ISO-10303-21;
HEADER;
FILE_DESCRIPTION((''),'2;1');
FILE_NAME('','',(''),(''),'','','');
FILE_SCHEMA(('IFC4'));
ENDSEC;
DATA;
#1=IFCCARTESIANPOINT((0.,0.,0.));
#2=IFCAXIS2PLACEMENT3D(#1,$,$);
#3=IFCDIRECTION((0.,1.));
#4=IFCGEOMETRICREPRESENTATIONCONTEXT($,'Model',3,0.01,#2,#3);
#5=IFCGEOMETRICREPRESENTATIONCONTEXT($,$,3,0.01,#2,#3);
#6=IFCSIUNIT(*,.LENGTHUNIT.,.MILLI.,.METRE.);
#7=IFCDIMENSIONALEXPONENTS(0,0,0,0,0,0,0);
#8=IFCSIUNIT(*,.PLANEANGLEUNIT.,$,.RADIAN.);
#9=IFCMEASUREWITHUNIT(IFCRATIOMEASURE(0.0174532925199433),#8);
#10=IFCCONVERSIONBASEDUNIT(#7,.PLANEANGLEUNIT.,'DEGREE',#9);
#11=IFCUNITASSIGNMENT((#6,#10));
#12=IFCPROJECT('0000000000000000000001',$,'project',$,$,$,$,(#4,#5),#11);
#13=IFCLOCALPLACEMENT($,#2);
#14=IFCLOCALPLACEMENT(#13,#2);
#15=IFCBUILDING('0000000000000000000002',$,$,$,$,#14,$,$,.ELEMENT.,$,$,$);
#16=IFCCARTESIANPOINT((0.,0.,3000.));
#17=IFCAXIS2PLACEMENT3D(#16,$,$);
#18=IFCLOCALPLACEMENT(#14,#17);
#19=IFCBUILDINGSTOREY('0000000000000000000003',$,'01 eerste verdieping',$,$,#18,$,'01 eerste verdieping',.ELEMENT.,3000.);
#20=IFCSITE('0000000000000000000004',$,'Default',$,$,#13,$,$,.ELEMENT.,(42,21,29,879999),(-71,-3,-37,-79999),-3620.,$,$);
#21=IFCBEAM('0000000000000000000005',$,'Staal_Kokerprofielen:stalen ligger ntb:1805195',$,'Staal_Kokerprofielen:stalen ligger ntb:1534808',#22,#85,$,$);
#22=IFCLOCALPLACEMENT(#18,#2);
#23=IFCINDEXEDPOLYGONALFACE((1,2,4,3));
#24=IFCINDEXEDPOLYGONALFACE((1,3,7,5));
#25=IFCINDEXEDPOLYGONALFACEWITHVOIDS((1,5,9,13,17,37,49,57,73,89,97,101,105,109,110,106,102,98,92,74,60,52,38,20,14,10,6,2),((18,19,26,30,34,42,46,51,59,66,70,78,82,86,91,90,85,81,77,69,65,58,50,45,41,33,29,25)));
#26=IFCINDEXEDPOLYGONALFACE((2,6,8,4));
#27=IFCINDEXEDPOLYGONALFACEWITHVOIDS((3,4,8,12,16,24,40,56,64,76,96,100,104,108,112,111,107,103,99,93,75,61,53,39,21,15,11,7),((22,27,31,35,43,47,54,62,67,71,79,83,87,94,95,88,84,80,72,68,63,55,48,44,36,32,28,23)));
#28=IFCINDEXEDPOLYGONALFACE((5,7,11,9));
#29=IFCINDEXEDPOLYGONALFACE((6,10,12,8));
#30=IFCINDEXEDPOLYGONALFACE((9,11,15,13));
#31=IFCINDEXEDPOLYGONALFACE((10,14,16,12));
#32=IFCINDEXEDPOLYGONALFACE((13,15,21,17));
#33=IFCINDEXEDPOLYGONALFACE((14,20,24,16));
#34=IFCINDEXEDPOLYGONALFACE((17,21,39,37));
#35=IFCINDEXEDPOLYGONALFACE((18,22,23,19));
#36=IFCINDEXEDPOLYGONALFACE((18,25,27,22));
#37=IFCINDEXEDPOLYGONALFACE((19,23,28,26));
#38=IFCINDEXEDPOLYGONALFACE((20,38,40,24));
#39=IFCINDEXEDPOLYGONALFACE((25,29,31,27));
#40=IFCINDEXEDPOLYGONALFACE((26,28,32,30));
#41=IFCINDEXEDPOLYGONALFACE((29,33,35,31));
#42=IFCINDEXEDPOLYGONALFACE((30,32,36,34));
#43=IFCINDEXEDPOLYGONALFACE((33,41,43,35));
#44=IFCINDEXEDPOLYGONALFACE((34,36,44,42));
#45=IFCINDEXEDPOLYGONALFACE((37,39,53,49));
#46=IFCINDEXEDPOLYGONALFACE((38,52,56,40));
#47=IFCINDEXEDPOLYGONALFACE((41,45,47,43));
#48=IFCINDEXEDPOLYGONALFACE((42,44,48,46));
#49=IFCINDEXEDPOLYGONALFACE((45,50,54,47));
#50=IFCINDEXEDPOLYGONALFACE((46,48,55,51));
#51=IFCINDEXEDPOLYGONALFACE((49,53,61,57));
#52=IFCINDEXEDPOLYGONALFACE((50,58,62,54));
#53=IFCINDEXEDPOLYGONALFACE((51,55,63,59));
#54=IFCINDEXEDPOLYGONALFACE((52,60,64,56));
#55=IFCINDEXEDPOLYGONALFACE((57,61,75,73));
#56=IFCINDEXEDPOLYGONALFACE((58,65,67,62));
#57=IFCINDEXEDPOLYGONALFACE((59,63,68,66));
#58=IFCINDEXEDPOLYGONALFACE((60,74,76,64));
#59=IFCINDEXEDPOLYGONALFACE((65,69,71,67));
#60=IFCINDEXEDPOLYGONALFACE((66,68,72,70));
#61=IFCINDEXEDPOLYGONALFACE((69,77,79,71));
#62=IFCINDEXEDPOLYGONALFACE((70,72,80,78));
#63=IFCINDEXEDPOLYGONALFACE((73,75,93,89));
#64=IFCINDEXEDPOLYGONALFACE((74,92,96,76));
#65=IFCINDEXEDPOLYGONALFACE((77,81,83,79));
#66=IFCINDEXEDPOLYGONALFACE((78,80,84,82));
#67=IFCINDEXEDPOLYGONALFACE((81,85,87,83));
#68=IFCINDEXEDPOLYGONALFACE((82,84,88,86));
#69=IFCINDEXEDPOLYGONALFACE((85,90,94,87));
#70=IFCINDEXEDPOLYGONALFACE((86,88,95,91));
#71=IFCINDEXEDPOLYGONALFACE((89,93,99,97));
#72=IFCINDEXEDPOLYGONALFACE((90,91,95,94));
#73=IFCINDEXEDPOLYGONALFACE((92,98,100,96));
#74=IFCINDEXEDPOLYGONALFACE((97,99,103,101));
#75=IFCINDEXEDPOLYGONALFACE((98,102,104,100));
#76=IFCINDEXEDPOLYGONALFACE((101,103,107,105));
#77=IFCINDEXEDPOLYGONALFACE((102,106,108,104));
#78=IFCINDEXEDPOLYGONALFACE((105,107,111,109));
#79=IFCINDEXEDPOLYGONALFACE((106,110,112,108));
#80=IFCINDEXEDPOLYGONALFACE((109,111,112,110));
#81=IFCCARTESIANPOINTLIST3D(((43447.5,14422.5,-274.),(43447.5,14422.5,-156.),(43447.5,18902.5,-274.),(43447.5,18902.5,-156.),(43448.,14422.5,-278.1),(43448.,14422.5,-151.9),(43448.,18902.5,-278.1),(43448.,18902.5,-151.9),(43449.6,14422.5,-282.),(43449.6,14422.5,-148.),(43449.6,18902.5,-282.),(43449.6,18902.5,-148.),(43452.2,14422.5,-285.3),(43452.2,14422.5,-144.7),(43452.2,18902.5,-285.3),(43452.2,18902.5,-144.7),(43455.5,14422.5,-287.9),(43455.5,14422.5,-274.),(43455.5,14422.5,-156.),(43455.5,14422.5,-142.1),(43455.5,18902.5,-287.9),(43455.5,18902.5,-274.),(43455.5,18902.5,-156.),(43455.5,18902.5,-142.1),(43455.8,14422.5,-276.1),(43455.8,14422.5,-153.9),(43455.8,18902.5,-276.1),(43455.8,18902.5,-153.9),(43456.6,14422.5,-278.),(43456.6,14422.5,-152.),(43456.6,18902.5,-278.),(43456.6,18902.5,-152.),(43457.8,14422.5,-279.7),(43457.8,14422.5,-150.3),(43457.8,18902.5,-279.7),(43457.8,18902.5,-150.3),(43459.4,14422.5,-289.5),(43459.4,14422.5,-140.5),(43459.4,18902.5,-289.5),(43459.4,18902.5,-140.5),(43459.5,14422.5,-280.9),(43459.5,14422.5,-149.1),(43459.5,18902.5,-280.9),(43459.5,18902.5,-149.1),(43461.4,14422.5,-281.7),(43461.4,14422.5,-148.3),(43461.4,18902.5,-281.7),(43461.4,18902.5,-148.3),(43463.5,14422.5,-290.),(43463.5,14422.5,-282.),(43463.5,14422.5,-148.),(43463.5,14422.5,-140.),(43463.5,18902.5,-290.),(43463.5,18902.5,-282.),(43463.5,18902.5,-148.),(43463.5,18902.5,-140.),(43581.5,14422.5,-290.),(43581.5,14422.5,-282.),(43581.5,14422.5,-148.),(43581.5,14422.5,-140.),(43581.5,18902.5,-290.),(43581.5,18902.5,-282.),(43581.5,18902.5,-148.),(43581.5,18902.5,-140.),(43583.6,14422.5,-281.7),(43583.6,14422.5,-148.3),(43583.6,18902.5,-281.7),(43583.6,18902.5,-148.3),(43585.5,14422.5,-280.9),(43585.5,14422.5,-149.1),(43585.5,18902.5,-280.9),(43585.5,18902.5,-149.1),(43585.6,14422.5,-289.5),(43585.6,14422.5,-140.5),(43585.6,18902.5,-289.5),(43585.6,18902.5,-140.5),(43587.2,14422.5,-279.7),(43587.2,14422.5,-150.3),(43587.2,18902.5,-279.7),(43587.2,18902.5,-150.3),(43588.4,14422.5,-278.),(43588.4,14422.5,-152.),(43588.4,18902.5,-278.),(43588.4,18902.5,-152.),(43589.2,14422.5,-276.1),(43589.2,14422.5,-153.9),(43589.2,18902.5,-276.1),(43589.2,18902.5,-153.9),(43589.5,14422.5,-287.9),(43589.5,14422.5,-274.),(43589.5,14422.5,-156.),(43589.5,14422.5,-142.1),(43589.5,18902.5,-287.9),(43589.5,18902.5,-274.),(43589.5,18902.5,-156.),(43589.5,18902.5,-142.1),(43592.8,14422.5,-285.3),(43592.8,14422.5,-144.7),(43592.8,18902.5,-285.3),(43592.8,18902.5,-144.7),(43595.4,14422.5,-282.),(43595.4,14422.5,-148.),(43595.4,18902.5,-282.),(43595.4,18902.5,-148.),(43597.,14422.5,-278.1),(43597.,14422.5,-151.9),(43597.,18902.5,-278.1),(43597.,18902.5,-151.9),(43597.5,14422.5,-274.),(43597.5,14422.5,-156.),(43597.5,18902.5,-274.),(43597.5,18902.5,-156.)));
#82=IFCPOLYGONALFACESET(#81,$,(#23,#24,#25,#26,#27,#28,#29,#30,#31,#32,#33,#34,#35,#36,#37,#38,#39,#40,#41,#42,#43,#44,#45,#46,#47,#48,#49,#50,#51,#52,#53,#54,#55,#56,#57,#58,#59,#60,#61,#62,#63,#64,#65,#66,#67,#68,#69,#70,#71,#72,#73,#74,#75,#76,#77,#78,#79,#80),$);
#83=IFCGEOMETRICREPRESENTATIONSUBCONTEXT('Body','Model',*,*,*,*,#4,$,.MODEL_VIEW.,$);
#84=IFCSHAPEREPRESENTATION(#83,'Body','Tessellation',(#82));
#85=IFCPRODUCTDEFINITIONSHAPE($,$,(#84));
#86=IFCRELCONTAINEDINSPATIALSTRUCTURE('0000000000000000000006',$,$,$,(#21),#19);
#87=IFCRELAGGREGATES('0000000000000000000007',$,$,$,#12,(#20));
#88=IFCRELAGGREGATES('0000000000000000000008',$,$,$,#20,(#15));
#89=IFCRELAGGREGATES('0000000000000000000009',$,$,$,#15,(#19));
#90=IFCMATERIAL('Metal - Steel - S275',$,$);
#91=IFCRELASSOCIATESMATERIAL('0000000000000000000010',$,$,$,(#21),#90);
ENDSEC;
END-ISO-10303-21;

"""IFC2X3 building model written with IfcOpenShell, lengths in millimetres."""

from ifc_helpers import new_model, entity, si_unit, converted_unit, direction, frame, frame_2d, origin, place, context, subcontext, project, spatial, polyline, circle_curve, parameter, trimmed, segment, composite_curve, outline, extrude, material, element, save


model = new_model("IFC2X3")

# Units and contexts
model_context = context("Model", 3, precision=0.01, world=origin(), true_north=direction((0.0, 1.0)))
context_of_model = context(None, 3, precision=0.01, world=origin(), true_north=direction((0.0, 1.0)))
body_context = subcontext(model_context, "Body", "Model", "MODEL_VIEW")
ifc_project = project(units=[si_unit("LENGTHUNIT", "METRE", prefix="MILLI"), converted_unit("PLANEANGLEUNIT", "DEGREE", entity("IfcRatioMeasure", 0.0174532925199433), si_unit("PLANEANGLEUNIT", "RADIAN"), dimensions=[0, 0, 0, 0, 0, 0, 0])], contexts=[model_context, context_of_model])

# Site, building, storey
site_placement = place(None, origin())
site = spatial("IfcSite", under=ifc_project, at=site_placement, Name="Default", CompositionType="ELEMENT", RefLatitude=(42, 21, 29, 879999), RefLongitude=(-71, -3, -37, -79999), RefElevation=-3620.0)
building_placement = place(site_placement, origin())
building = spatial("IfcBuilding", under=site, at=building_placement, CompositionType="ELEMENT")
storey_placement = place(building_placement, frame((0.0, 0.0, 3000.0)))
storey = spatial("IfcBuildingStorey", under=building, at=storey_placement, Name="01 eerste verdieping", LongName="01 eerste verdieping", CompositionType="ELEMENT", Elevation=3000.0)

# Beam
ifc_material_1 = material(Name="Metal - Steel - S275")
beam_placement = place(storey_placement, frame((43522.5, 18902.5, 0.0), z_axis=(0.0, 0.0, 1.0), x_axis=(0.0, -1.0, 0.0)))
element("IfcBeam", 1, at=beam_placement, inside=storey, material=ifc_material_1, Name="Staal_Kokerprofielen:stalen ligger ntb:1805195", ObjectType="Staal_Kokerprofielen:stalen ligger ntb:1534808", context=body_context, shape_type="SweptSolid", body=[
    extrude(outline(composite_curve([segment(trimmed(circle_curve(frame_2d((59.0, -59.0), x_axis=(1.0, 0.0)), 16.0), [parameter(270.0)], [parameter(360.0)], True, "PARAMETER"), True, "CONTINUOUS"), segment(polyline([(75.0, -59.0), (75.0, 59.0)]), True, "CONTINUOUS"), segment(trimmed(circle_curve(frame_2d((59.0, 59.0), x_axis=(0.0, 1.0)), 16.0), [parameter(270.0)], [parameter(360.0)], True, "PARAMETER"), True, "CONTINUOUS"), segment(polyline([(59.0, 75.0), (-59.0, 75.0)]), True, "CONTINUOUS"), segment(trimmed(circle_curve(frame_2d((-59.0, 59.0), x_axis=(-1.0, 0.0)), 16.0), [parameter(270.0)], [parameter(0.0)], True, "PARAMETER"), True, "CONTINUOUS"), segment(polyline([(-75.0, 59.0), (-75.0, -59.0)]), True, "CONTINUOUS"), segment(trimmed(circle_curve(frame_2d((-59.0, -59.0), x_axis=(0.0, -1.0)), 16.0), [parameter(270.0)], [parameter(0.0)], True, "PARAMETER"), True, "CONTINUOUS"), segment(polyline([(-59.0, -75.0), (59.0, -75.0)]), True, "CONTINUOUS")], self_intersect=False), holes=[composite_curve([segment(polyline([(67.0, 59.0), (67.0, -59.0)]), True, "CONTINUOUS"), segment(trimmed(circle_curve(frame_2d((59.0, -59.0), x_axis=(0.0, -1.0)), 8.0), [parameter(0.0)], [parameter(90.0)], True, "PARAMETER"), False, "CONTINUOUS"), segment(polyline([(59.0, -67.0), (-59.0, -67.0)]), True, "CONTINUOUS"), segment(trimmed(circle_curve(frame_2d((-59.0, -59.0), x_axis=(-1.0, 0.0)), 8.0), [parameter(0.0)], [parameter(90.0)], True, "PARAMETER"), False, "CONTINUOUS"), segment(polyline([(-67.0, -59.0), (-67.0, 59.0)]), True, "CONTINUOUS"), segment(trimmed(circle_curve(frame_2d((-59.0, 59.0), x_axis=(0.0, 1.0)), 8.0), [parameter(0.0)], [parameter(90.0)], True, "PARAMETER"), False, "CONTINUOUS"), segment(polyline([(-59.0, 67.0), (59.0, 67.0)]), True, "CONTINUOUS"), segment(trimmed(circle_curve(frame_2d((59.0, 59.0), x_axis=(1.0, 0.0)), 8.0), [parameter(0.0)], [parameter(90.0)], True, "PARAMETER"), False, "CONTINUOUS")], self_intersect=False)]), frame((0.0, 0.0, -215.0), z_axis=(1.0, 0.0, 0.0), x_axis=(0.0, 0.0, 1.0)), (0.0, 0.0, 1.0), 4480.0),
])

save(model, "model.ifc")
